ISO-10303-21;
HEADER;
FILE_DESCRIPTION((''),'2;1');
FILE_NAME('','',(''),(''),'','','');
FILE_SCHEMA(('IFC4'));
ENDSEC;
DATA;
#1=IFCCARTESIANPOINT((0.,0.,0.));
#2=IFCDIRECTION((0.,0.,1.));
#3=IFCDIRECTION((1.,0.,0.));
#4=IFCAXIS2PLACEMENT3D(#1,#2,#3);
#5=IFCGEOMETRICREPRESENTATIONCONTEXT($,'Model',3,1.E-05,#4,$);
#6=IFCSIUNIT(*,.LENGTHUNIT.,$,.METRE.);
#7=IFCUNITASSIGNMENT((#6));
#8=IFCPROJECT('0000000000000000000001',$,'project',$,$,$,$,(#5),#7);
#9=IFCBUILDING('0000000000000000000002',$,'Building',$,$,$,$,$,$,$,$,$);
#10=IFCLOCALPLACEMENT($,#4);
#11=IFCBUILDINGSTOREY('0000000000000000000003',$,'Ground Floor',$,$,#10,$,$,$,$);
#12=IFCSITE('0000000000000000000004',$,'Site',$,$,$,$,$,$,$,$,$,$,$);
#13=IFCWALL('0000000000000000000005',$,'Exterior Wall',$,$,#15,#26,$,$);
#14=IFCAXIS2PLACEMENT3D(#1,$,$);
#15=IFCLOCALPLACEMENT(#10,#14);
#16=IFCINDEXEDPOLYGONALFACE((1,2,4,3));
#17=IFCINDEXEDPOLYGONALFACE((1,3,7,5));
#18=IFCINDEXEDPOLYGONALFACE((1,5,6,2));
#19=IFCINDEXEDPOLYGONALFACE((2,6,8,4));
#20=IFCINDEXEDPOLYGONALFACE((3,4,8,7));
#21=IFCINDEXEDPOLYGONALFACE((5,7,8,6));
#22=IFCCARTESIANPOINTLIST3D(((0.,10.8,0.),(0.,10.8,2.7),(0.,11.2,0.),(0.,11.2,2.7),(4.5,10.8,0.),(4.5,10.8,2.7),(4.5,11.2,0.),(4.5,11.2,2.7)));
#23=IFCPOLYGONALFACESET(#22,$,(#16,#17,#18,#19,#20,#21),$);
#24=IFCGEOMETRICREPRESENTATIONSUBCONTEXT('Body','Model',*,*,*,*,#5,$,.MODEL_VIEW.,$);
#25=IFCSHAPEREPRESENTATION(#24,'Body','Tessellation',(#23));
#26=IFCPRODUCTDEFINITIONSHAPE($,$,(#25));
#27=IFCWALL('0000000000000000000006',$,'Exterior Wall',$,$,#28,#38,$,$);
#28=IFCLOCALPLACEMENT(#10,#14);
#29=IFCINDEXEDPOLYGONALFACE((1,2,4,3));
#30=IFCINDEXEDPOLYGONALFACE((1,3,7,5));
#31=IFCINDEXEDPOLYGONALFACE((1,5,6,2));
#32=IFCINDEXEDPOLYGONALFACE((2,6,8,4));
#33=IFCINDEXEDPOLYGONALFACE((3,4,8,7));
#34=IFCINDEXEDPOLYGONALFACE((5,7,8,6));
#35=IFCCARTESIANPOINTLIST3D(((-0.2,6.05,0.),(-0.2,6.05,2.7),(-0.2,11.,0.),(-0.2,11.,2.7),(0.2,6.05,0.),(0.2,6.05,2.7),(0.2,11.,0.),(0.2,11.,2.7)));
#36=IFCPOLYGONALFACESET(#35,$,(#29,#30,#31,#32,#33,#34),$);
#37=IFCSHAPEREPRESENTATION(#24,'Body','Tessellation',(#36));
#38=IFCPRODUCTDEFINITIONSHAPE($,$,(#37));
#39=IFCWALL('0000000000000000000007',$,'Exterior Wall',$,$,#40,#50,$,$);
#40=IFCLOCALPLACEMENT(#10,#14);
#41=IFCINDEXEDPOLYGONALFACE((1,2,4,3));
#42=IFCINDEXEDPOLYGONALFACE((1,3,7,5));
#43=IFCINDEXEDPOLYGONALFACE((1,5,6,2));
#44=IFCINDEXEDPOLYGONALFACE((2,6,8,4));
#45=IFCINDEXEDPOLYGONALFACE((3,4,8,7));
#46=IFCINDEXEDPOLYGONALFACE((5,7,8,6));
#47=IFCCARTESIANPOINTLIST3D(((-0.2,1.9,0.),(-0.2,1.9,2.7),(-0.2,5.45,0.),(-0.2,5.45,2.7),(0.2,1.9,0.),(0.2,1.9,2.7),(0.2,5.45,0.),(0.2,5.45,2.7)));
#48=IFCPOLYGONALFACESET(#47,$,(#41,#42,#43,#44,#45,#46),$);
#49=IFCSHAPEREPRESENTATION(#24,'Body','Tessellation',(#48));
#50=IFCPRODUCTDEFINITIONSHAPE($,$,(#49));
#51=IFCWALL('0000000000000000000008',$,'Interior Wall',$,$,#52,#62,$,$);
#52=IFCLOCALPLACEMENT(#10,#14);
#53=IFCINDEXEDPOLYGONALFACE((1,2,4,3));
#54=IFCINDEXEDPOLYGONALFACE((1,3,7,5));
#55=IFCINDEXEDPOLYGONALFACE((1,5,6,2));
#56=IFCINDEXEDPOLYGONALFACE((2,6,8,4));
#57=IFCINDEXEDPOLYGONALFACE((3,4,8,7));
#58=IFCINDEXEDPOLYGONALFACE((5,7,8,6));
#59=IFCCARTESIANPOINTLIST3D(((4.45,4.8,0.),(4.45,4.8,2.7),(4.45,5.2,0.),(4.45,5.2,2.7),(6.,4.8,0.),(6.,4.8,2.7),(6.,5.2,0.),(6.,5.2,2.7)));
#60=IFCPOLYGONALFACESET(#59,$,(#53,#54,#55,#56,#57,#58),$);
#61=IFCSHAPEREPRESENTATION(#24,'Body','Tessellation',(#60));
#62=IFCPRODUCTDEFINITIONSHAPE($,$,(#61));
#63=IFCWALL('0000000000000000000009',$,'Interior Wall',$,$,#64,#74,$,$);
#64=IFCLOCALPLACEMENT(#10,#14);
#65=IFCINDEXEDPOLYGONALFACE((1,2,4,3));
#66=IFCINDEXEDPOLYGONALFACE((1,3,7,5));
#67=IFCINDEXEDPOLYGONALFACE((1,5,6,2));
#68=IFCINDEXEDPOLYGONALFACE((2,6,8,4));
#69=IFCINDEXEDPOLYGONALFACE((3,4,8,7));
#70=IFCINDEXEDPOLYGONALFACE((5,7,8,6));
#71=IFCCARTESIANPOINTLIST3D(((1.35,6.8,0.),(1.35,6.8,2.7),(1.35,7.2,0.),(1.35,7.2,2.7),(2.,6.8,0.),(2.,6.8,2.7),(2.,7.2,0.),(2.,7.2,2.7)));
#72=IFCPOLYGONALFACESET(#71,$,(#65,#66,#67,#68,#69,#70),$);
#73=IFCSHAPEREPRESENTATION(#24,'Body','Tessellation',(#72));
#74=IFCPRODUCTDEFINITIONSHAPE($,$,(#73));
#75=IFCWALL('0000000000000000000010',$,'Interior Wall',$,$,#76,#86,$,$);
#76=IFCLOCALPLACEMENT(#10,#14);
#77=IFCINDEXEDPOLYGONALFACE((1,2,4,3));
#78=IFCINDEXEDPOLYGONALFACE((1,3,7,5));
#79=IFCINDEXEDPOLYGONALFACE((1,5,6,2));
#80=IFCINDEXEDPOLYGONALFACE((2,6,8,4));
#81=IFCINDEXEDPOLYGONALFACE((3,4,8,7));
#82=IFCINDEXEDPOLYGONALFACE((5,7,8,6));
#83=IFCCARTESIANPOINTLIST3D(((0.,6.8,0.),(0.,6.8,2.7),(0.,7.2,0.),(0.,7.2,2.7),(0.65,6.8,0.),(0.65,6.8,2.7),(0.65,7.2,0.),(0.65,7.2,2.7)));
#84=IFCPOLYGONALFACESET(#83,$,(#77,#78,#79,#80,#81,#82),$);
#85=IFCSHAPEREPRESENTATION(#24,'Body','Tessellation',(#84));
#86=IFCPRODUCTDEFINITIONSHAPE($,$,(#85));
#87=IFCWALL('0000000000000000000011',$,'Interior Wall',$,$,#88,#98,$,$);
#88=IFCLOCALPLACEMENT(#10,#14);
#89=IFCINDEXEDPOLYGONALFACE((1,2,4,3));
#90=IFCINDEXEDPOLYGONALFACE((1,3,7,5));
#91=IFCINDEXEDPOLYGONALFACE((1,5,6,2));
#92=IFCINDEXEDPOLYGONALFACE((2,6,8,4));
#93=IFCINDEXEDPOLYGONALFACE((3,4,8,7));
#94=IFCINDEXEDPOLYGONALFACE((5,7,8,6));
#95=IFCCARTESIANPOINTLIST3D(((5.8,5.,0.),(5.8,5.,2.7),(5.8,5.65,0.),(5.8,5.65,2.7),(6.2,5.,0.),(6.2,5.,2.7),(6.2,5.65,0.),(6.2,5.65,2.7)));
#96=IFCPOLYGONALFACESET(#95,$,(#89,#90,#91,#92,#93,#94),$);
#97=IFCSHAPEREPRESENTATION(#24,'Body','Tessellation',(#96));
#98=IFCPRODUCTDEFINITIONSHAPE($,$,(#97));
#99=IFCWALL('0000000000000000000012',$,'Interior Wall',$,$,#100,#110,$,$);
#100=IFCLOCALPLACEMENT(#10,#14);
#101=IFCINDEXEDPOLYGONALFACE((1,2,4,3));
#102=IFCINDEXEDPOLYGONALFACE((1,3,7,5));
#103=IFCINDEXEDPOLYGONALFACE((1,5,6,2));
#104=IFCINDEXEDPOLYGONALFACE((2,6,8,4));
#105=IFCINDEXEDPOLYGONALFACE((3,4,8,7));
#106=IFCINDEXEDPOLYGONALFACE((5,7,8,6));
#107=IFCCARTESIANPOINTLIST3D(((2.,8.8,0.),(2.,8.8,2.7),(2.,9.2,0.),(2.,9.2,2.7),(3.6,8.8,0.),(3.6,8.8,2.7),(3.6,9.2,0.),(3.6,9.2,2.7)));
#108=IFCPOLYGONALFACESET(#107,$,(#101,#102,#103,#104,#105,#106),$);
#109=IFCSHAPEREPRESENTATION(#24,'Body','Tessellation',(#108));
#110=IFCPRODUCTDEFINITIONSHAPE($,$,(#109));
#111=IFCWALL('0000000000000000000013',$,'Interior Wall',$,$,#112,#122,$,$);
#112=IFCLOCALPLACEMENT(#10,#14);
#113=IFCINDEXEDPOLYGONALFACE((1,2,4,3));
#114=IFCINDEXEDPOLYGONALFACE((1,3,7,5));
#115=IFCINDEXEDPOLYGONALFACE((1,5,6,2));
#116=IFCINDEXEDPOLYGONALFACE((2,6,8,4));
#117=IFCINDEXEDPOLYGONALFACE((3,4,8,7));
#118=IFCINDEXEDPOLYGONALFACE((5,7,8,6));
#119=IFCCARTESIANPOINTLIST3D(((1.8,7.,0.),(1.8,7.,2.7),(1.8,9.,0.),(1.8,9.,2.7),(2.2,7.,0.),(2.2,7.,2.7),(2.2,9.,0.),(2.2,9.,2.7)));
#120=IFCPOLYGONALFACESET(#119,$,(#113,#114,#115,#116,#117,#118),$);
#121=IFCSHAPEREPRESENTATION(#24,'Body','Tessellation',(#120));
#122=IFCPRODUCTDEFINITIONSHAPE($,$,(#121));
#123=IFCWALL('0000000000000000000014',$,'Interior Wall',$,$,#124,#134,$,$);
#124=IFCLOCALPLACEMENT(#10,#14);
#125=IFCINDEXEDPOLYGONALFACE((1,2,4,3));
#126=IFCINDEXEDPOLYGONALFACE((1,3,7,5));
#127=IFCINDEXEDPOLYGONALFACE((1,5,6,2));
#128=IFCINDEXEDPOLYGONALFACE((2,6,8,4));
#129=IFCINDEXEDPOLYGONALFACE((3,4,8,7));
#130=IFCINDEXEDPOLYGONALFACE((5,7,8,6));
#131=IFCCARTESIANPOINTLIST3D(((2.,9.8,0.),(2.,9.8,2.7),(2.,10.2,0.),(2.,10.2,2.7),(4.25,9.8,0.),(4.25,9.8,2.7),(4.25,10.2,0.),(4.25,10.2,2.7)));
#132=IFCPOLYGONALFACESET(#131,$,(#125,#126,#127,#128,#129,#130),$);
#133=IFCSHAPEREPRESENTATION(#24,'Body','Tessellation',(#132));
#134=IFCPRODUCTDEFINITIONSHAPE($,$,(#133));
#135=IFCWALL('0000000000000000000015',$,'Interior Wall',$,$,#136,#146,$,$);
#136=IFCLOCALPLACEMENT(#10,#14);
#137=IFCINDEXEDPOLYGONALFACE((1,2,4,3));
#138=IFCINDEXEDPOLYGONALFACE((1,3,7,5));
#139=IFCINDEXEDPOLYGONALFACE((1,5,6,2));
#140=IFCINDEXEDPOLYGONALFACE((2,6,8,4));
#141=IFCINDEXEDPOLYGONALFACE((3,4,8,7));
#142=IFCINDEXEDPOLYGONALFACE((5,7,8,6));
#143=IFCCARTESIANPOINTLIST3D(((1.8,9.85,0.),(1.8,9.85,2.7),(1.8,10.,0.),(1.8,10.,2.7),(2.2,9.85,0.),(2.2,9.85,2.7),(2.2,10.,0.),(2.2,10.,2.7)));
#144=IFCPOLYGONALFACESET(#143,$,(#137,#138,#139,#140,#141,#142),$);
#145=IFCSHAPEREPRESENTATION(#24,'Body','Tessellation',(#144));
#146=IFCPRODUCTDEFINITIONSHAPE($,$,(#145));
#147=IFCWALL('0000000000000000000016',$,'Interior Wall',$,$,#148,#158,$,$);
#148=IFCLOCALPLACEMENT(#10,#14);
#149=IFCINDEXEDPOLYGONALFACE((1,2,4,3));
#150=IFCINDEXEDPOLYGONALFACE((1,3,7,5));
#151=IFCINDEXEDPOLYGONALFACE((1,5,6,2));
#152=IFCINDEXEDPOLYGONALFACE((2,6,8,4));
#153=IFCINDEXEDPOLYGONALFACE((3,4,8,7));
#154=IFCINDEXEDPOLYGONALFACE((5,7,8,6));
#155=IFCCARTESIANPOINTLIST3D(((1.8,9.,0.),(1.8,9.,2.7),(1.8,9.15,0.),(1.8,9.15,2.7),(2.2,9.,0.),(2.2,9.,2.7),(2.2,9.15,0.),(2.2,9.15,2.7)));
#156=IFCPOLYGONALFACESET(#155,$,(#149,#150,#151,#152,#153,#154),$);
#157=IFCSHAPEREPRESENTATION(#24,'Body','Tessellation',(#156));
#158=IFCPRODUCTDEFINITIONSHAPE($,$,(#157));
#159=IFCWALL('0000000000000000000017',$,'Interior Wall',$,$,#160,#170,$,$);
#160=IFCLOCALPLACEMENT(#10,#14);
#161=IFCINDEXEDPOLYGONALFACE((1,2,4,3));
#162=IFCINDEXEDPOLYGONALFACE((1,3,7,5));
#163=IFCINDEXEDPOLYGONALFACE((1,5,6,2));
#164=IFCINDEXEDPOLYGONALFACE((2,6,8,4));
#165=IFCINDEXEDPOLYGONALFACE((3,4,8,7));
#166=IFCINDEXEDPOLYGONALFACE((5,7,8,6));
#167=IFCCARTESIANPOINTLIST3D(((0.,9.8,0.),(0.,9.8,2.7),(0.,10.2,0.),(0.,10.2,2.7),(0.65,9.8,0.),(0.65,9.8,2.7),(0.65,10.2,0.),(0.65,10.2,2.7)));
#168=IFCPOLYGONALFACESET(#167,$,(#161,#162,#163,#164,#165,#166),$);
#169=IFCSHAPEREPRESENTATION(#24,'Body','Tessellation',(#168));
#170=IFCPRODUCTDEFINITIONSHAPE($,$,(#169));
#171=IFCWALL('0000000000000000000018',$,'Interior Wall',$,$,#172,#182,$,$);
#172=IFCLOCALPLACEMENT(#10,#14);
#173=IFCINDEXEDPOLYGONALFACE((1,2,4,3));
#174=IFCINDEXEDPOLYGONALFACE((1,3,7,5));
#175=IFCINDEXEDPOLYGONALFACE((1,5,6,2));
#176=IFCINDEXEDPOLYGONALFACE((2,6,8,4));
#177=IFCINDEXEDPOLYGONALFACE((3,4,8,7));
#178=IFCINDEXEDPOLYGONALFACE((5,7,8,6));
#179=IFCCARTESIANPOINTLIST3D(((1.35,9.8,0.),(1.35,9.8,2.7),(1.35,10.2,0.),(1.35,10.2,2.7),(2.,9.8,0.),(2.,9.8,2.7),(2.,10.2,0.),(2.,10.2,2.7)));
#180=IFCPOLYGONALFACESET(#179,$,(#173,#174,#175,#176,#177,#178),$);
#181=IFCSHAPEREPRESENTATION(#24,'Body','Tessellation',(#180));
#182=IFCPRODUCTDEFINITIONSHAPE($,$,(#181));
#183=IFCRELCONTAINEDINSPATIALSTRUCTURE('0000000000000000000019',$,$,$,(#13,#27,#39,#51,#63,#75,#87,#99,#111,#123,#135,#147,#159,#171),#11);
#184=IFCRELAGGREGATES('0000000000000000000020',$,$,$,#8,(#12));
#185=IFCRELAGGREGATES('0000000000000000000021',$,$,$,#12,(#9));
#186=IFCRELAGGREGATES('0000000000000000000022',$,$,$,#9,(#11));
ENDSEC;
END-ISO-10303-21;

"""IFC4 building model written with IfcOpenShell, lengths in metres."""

from ifc_helpers import new_model, si_unit, frame, origin_with_axes, place, context, subcontext, project, spatial, indexed_curve, outline, extrude, element, save


model = new_model("IFC4")

# Units and contexts
model_context = context("Model", 3, precision=1e-05, world=origin_with_axes())
body_context = subcontext(model_context, "Body", "Model", "MODEL_VIEW")
ifc_project = project(units=[si_unit("LENGTHUNIT", "METRE")], contexts=[model_context])

# Site, building, storey
site = spatial("IfcSite", under=ifc_project, Name="Site")
building = spatial("IfcBuilding", under=site, Name="Building")
storey_placement = place(None, origin_with_axes())
storey = spatial("IfcBuildingStorey", under=building, at=storey_placement, Name="Ground Floor")

# Walls
wall_1_placement = place(storey_placement, frame((4.5, 11.0, 0.0), z_axis=(0.0, 0.0, 1.0), x_axis=(-1.0, 0.0, 0.0)))
element("IfcWall", 1, at=wall_1_placement, inside=storey, Name="Exterior Wall", context=body_context, shape_type="SweptSolid", body=[
    extrude(outline(indexed_curve([(0.0, 0.0), (0.0, 0.4), (4.5, 0.4), (4.5, 0.0), (0.0, 0.0)], self_intersect=False)), frame((0.0, -0.2, 0.0), z_axis=(0.0, 0.0, 1.0), x_axis=(1.0, 0.0, 0.0)), (0.0, 0.0, 1.0), 2.7),
])
wall_2_placement = place(storey_placement, frame((0.0, 11.0, 0.0), z_axis=(0.0, 0.0, 1.0), x_axis=(0.0, -1.0, 0.0)))
element("IfcWall", 2, at=wall_2_placement, inside=storey, Name="Exterior Wall", context=body_context, shape_type="SweptSolid", body=[
    extrude(outline(indexed_curve([(0.0, 0.0), (0.0, 0.4), (4.95, 0.4), (4.95, 0.0), (0.0, 0.0)], self_intersect=False)), frame((0.0, -0.2, 0.0), z_axis=(0.0, 0.0, 1.0), x_axis=(1.0, 0.0, 0.0)), (0.0, 0.0, 1.0), 2.7),
])
wall_3_placement = place(storey_placement, frame((0.0, 5.45, 0.0), z_axis=(0.0, 0.0, 1.0), x_axis=(0.0, -1.0, 0.0)))
element("IfcWall", 3, at=wall_3_placement, inside=storey, Name="Exterior Wall", context=body_context, shape_type="SweptSolid", body=[
    extrude(outline(indexed_curve([(0.0, 0.0), (0.0, 0.4), (3.55, 0.4), (3.55, 0.0), (0.0, 0.0)], self_intersect=False)), frame((0.0, -0.2, 0.0), z_axis=(0.0, 0.0, 1.0), x_axis=(1.0, 0.0, 0.0)), (0.0, 0.0, 1.0), 2.7),
])
wall_4_placement = place(storey_placement, frame((6.0, 5.0, 0.0), z_axis=(0.0, 0.0, 1.0), x_axis=(-1.0, 0.0, 0.0)))
element("IfcWall", 4, at=wall_4_placement, inside=storey, Name="Interior Wall", context=body_context, shape_type="SweptSolid", body=[
    extrude(outline(indexed_curve([(0.0, 0.0), (0.0, 0.4), (1.55, 0.4), (1.55, 0.0), (0.0, 0.0)], self_intersect=False)), frame((0.0, -0.2, 0.0), z_axis=(0.0, 0.0, 1.0), x_axis=(1.0, 0.0, 0.0)), (0.0, 0.0, 1.0), 2.7),
])
for number, where, z_axis, x_axis, name in (
    (5, (2.0, 7.0, 0.0), (0.0, 0.0, 1.0), (-1.0, 0.0, 0.0), "Interior Wall"),
    (6, (0.65, 7.0, 0.0), (0.0, 0.0, 1.0), (-1.0, 0.0, 0.0), "Interior Wall"),
):
    element("IfcWall", number, at=place(storey_placement, frame(where, z_axis=z_axis, x_axis=x_axis)), inside=storey, Name=name, context=body_context, shape_type="SweptSolid", body=[
        extrude(outline(indexed_curve([(0.0, 0.0), (0.0, 0.4), (0.65, 0.4), (0.65, 0.0), (0.0, 0.0)], self_intersect=False)), frame((0.0, -0.2, 0.0), z_axis=(0.0, 0.0, 1.0), x_axis=(1.0, 0.0, 0.0)), (0.0, 0.0, 1.0), 2.7),
    ])
wall_5_placement = place(storey_placement, frame((6.0, 5.0, 0.0), z_axis=(0.0, 0.0, 1.0), x_axis=(0.0, 1.0, 0.0)))
element("IfcWall", 7, at=wall_5_placement, inside=storey, Name="Interior Wall", context=body_context, shape_type="SweptSolid", body=[
    extrude(outline(indexed_curve([(0.0, 0.0), (0.0, 0.4), (0.65, 0.4), (0.65, 0.0), (0.0, 0.0)], self_intersect=False)), frame((0.0, -0.2, 0.0), z_axis=(0.0, 0.0, 1.0), x_axis=(1.0, 0.0, 0.0)), (0.0, 0.0, 1.0), 2.7),
])
wall_6_placement = place(storey_placement, frame((3.6, 9.0, 0.0), z_axis=(0.0, 0.0, 1.0), x_axis=(-1.0, 0.0, 0.0)))
element("IfcWall", 8, at=wall_6_placement, inside=storey, Name="Interior Wall", context=body_context, shape_type="SweptSolid", body=[
    extrude(outline(indexed_curve([(0.0, 0.0), (0.0, 0.4), (1.6, 0.4), (1.6, 0.0), (0.0, 0.0)], self_intersect=False)), frame((0.0, -0.2, 0.0), z_axis=(0.0, 0.0, 1.0), x_axis=(1.0, 0.0, 0.0)), (0.0, 0.0, 1.0), 2.7),
])
wall_7_placement = place(storey_placement, frame((2.0, 9.0, 0.0), z_axis=(0.0, 0.0, 1.0), x_axis=(0.0, -1.0, 0.0)))
element("IfcWall", 9, at=wall_7_placement, inside=storey, Name="Interior Wall", context=body_context, shape_type="SweptSolid", body=[
    extrude(outline(indexed_curve([(0.0, 0.0), (0.0, 0.4), (2.0, 0.4), (2.0, 0.0), (0.0, 0.0)], self_intersect=False)), frame((0.0, -0.2, 0.0), z_axis=(0.0, 0.0, 1.0), x_axis=(1.0, 0.0, 0.0)), (0.0, 0.0, 1.0), 2.7),
])
wall_8_placement = place(storey_placement, frame((4.25, 10.0, 0.0), z_axis=(0.0, 0.0, 1.0), x_axis=(-1.0, 0.0, 0.0)))
element("IfcWall", 10, at=wall_8_placement, inside=storey, Name="Interior Wall", context=body_context, shape_type="SweptSolid", body=[
    extrude(outline(indexed_curve([(0.0, 0.0), (0.0, 0.4), (2.25, 0.4), (2.25, 0.0), (0.0, 0.0)], self_intersect=False)), frame((0.0, -0.2, 0.0), z_axis=(0.0, 0.0, 1.0), x_axis=(1.0, 0.0, 0.0)), (0.0, 0.0, 1.0), 2.7),
])
for number, where, z_axis, x_axis, name in (
    (11, (2.0, 10.0, 0.0), (0.0, 0.0, 1.0), (0.0, -1.0, 0.0), "Interior Wall"),
    (12, (2.0, 9.15, 0.0), (0.0, 0.0, 1.0), (0.0, -1.0, 0.0), "Interior Wall"),
):
    element("IfcWall", number, at=place(storey_placement, frame(where, z_axis=z_axis, x_axis=x_axis)), inside=storey, Name=name, context=body_context, shape_type="SweptSolid", body=[
        extrude(outline(indexed_curve([(0.0, 0.0), (0.0, 0.4), (0.15, 0.4), (0.15, 0.0), (0.0, 0.0)], self_intersect=False)), frame((0.0, -0.2, 0.0), z_axis=(0.0, 0.0, 1.0), x_axis=(1.0, 0.0, 0.0)), (0.0, 0.0, 1.0), 2.7),
    ])
wall_9_placement = place(storey_placement, frame((0.0, 10.0, 0.0), z_axis=(0.0, 0.0, 1.0), x_axis=(1.0, 0.0, 0.0)))
element("IfcWall", 13, at=wall_9_placement, inside=storey, Name="Interior Wall", context=body_context, shape_type="SweptSolid", body=[
    extrude(outline(indexed_curve([(0.0, 0.0), (0.0, 0.4), (0.65, 0.4), (0.65, 0.0), (0.0, 0.0)], self_intersect=False)), frame((0.0, -0.2, 0.0), z_axis=(0.0, 0.0, 1.0), x_axis=(1.0, 0.0, 0.0)), (0.0, 0.0, 1.0), 2.7),
])
wall_10_placement = place(storey_placement, frame((1.35, 10.0, 0.0), z_axis=(0.0, 0.0, 1.0), x_axis=(1.0, 0.0, 0.0)))
element("IfcWall", 14, at=wall_10_placement, inside=storey, Name="Interior Wall", context=body_context, shape_type="SweptSolid", body=[
    extrude(outline(indexed_curve([(0.0, 0.0), (0.0, 0.4), (0.65, 0.4), (0.65, 0.0), (0.0, 0.0)], self_intersect=False)), frame((0.0, -0.2, 0.0), z_axis=(0.0, 0.0, 1.0), x_axis=(1.0, 0.0, 0.0)), (0.0, 0.0, 1.0), 2.7),
])

save(model, "model.ifc")
